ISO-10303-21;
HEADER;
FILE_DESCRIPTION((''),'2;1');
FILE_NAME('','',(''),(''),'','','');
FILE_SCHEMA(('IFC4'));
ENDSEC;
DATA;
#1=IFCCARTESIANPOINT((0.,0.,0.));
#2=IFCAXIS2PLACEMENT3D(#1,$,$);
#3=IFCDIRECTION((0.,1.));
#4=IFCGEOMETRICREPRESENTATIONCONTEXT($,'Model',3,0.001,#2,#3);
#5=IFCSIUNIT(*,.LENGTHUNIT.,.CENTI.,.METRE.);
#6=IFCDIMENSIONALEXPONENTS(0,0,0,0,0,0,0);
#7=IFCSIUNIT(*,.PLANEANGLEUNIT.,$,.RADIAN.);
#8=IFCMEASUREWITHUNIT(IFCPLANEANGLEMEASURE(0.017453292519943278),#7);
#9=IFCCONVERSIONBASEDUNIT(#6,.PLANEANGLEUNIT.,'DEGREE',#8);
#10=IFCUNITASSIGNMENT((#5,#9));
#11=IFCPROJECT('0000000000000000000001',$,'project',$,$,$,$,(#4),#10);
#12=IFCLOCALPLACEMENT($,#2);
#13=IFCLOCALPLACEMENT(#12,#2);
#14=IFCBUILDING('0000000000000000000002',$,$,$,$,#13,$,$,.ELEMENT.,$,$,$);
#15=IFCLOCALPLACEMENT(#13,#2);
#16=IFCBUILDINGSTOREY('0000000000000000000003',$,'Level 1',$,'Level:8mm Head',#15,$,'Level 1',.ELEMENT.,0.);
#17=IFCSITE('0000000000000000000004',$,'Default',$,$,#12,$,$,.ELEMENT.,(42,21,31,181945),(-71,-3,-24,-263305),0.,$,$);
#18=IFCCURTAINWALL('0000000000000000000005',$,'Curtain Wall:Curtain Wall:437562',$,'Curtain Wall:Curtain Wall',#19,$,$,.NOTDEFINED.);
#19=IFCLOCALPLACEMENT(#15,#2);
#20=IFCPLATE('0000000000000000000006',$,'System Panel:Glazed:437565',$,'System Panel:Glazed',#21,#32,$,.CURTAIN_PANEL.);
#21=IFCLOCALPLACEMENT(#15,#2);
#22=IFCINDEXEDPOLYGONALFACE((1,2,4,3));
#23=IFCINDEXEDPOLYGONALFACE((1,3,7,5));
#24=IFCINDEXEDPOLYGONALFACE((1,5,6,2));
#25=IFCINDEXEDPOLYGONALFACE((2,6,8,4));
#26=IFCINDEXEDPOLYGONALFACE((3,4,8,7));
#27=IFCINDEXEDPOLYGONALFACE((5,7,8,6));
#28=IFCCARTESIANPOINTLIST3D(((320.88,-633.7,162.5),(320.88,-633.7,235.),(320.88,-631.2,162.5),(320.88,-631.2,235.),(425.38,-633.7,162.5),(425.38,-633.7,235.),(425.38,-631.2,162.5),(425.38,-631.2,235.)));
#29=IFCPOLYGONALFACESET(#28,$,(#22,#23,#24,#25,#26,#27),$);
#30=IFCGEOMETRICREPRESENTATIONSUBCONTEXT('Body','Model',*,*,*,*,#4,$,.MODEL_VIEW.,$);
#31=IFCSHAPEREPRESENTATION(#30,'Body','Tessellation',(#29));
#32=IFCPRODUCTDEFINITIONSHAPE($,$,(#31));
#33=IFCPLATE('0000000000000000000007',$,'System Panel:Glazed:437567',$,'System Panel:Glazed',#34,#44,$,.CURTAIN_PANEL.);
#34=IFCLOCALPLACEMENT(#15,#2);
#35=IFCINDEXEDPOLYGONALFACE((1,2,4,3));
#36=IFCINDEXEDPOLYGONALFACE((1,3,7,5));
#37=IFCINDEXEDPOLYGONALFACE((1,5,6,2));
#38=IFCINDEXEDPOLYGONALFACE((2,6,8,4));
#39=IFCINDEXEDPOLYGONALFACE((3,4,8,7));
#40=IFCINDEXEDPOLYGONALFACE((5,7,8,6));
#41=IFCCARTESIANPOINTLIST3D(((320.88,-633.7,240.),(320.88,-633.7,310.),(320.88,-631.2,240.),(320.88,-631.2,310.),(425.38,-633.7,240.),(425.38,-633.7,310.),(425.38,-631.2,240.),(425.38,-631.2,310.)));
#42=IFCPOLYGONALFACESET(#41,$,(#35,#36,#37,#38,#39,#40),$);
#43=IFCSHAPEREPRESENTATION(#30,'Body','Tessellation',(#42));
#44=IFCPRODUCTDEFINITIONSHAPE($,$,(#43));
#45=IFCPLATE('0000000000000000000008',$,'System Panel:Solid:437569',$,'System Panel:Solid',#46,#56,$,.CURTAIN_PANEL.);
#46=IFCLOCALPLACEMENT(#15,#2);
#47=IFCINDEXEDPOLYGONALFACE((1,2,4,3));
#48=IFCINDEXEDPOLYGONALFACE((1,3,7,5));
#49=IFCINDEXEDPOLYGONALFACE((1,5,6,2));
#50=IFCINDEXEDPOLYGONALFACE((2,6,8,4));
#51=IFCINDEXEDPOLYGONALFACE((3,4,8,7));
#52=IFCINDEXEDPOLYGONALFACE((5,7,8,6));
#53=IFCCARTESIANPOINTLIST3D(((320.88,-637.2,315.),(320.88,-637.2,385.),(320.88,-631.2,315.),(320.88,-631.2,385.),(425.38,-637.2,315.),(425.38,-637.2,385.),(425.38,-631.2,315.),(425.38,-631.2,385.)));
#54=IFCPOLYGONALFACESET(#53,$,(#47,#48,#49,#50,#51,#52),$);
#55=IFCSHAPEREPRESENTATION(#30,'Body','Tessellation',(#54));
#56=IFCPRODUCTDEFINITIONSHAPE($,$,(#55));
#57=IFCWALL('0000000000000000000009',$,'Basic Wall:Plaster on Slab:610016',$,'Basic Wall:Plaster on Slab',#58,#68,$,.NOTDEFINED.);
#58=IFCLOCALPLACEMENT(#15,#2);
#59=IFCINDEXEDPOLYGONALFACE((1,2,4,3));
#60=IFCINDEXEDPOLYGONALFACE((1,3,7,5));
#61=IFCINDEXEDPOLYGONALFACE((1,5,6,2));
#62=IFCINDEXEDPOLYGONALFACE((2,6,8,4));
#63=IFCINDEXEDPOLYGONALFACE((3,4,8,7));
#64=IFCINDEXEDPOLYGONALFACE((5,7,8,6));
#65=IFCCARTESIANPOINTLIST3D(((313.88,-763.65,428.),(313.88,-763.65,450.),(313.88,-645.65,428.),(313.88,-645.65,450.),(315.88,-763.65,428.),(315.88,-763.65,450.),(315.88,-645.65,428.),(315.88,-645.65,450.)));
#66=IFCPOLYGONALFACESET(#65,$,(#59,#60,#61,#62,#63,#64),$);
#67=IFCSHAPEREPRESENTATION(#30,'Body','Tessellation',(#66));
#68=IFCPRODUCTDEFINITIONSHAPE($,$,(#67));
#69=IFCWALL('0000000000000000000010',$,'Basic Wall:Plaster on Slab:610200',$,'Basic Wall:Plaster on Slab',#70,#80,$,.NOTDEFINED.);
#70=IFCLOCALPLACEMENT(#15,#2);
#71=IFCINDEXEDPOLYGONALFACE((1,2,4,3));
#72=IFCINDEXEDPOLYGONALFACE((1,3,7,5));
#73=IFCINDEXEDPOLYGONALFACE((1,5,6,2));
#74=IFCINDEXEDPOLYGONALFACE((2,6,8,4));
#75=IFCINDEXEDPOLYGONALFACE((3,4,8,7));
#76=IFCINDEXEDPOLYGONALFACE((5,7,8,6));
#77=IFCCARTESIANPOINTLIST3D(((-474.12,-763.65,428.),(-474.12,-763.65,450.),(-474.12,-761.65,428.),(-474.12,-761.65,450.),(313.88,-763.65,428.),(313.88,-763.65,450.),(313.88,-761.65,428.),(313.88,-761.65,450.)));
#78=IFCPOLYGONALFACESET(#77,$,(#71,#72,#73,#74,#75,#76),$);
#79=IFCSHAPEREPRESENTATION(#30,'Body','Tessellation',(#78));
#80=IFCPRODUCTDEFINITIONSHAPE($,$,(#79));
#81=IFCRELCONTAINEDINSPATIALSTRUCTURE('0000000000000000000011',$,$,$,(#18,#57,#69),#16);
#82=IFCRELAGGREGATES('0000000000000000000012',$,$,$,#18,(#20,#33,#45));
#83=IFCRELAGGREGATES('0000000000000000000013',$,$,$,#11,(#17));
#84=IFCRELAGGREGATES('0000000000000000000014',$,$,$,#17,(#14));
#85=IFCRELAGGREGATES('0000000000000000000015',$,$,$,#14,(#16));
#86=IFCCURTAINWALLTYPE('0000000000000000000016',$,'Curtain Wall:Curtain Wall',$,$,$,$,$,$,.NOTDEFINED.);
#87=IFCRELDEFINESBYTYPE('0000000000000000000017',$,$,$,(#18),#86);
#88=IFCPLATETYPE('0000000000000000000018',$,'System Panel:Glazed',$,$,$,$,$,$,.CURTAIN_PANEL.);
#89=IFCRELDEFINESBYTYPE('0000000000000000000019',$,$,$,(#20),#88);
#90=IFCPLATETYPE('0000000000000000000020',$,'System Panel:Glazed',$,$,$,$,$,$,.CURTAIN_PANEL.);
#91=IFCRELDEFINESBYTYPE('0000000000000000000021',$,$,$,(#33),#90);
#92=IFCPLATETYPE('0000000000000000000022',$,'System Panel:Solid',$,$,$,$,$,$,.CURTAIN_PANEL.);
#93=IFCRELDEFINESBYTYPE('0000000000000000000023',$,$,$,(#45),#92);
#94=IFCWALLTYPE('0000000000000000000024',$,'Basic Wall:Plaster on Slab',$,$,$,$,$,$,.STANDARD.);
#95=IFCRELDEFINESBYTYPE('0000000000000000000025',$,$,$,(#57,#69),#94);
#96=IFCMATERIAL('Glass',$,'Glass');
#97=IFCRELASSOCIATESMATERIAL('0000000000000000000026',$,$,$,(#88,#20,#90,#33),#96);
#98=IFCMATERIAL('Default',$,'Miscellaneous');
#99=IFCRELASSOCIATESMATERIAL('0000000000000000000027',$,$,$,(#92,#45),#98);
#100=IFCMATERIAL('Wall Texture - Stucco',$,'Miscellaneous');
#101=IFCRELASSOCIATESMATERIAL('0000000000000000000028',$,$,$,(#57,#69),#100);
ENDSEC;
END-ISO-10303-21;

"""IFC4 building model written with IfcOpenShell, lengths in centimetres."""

from ifc_helpers import new_model, entity, si_unit, converted_unit, direction, frame, origin, place, context, subcontext, project, spatial, indexed_curve, outline, extrude, source, transform, mapped, material, type_object, type_shapes, element, aggregate, save


model = new_model("IFC4")

# Units and contexts
model_context = context("Model", 3, precision=0.001, world=origin(), true_north=direction((0.0, 1.0)))
body_context = subcontext(model_context, "Body", "Model", "MODEL_VIEW")
ifc_project = project(units=[si_unit("LENGTHUNIT", "METRE", prefix="CENTI"), converted_unit("PLANEANGLEUNIT", "DEGREE", entity("IfcPlaneAngleMeasure", 0.017453292519943278), si_unit("PLANEANGLEUNIT", "RADIAN"), dimensions=[0, 0, 0, 0, 0, 0, 0])], contexts=[model_context])

# Site, building, storey
site_placement = place(None, origin())
site = spatial("IfcSite", under=ifc_project, at=site_placement, Name="Default", CompositionType="ELEMENT", RefLatitude=(42, 21, 31, 181945), RefLongitude=(-71, -3, -24, -263305), RefElevation=0.0)
building_placement = place(site_placement, origin())
building = spatial("IfcBuilding", under=site, at=building_placement, CompositionType="ELEMENT")
storey_placement = place(building_placement, origin())
storey = spatial("IfcBuildingStorey", under=building, at=storey_placement, Name="Level 1", ObjectType="Level:8mm Head", LongName="Level 1", CompositionType="ELEMENT", Elevation=0.0)

# Curtain wall
curtain_wall_type = type_object("IfcCurtainWallType", Name="Curtain Wall:Curtain Wall", PredefinedType="NOTDEFINED")
curtain_wall_1_placement = place(storey_placement, origin())
curtain_wall_1 = element("IfcCurtainWall", 1, at=curtain_wall_1_placement, inside=storey, type_object=curtain_wall_type, Name="Curtain Wall:Curtain Wall:437562", ObjectType="Curtain Wall:Curtain Wall", PredefinedType="NOTDEFINED")

# Plates
ifc_material_1 = material(Name="Glass", Category="Glass")
plate_type_1 = type_object("IfcPlateType", Name="System Panel:Glazed", PredefinedType="CURTAIN_PANEL", material=ifc_material_1)
shared_shape_1 = source(origin(), body_context, "Body", "SweptSolid", [
    extrude(outline(indexed_curve([(-1.25, -52.25), (1.25, -52.25), (1.25, 52.25), (-1.25, 52.25), (-1.25, -52.25)], self_intersect=False)), frame((0.0, 3.7, 0.0), z_axis=(0.0, 0.0, 1.0), x_axis=(0.0, 1.0, 0.0)), (0.0, 0.0, 1.0), 72.5),
])
type_shapes(plate_type_1, [shared_shape_1])
plate_1_placement = place(curtain_wall_1_placement, frame((373.13, -636.15, 162.5)))
plate_1 = element("IfcPlate", 2, at=plate_1_placement, type_object=plate_type_1, material=ifc_material_1, Name="System Panel:Glazed:437565", ObjectType="System Panel:Glazed", PredefinedType="CURTAIN_PANEL", context=body_context, shape_type="MappedRepresentation", body=[
    mapped(shared_shape_1, transform((0.0, 0.0, 0.0), scale=1.0)),
])
plate_type_2 = type_object("IfcPlateType", Name="System Panel:Glazed", PredefinedType="CURTAIN_PANEL", material=ifc_material_1)
shared_shape_2 = source(origin(), body_context, "Body", "SweptSolid", [
    extrude(outline(indexed_curve([(-1.25, -52.25), (1.25, -52.25), (1.25, 52.25), (-1.25, 52.25), (-1.25, -52.25)], self_intersect=False)), frame((0.0, 3.7, 0.0), z_axis=(0.0, 0.0, 1.0), x_axis=(0.0, 1.0, 0.0)), (0.0, 0.0, 1.0), 70.0),
])
type_shapes(plate_type_2, [shared_shape_2])
plate_2_placement = place(curtain_wall_1_placement, frame((373.13, -636.15, 240.0)))
plate_2 = element("IfcPlate", 3, at=plate_2_placement, type_object=plate_type_2, material=ifc_material_1, Name="System Panel:Glazed:437567", ObjectType="System Panel:Glazed", PredefinedType="CURTAIN_PANEL", context=body_context, shape_type="MappedRepresentation", body=[
    mapped(shared_shape_2, transform((0.0, 0.0, 0.0), scale=1.0)),
])
ifc_material_2 = material(Name="Default", Category="Miscellaneous")
plate_type_3 = type_object("IfcPlateType", Name="System Panel:Solid", PredefinedType="CURTAIN_PANEL", material=ifc_material_2)
shared_shape_3 = source(origin(), body_context, "Body", "SweptSolid", [
    extrude(outline(indexed_curve([(-3.0, -52.25), (3.0, -52.25), (3.0, 52.25), (-3.0, 52.25), (-3.0, -52.25)], self_intersect=False)), frame((0.0, 1.95, 0.0), z_axis=(0.0, 0.0, 1.0), x_axis=(0.0, 1.0, 0.0)), (0.0, 0.0, 1.0), 70.0),
])
type_shapes(plate_type_3, [shared_shape_3])
plate_3_placement = place(curtain_wall_1_placement, frame((373.13, -636.15, 315.0)))
plate_3 = element("IfcPlate", 4, at=plate_3_placement, type_object=plate_type_3, material=ifc_material_2, Name="System Panel:Solid:437569", ObjectType="System Panel:Solid", PredefinedType="CURTAIN_PANEL", context=body_context, shape_type="MappedRepresentation", body=[
    mapped(shared_shape_3, transform((0.0, 0.0, 0.0), scale=1.0)),
])
aggregate(curtain_wall_1, [plate_1, plate_2, plate_3])

# Walls
ifc_material_3 = material(Name="Wall Texture - Stucco", Category="Miscellaneous")
wall_type = type_object("IfcWallType", Name="Basic Wall:Plaster on Slab", PredefinedType="STANDARD")
wall_1_placement = place(storey_placement, frame((314.88, -645.65, 428.0), z_axis=(0.0, 0.0, 1.0), x_axis=(0.0, -1.0, 0.0)))
element("IfcWall", 5, at=wall_1_placement, inside=storey, type_object=wall_type, material=ifc_material_3, Name="Basic Wall:Plaster on Slab:610016", ObjectType="Basic Wall:Plaster on Slab", PredefinedType="NOTDEFINED", context=body_context, shape_type="SweptSolid", body=[
    extrude(outline(indexed_curve([(118.0, 1.0), (0.0, 1.0), (0.0, -1.0), (118.0, -1.0), (118.0, 1.0)], self_intersect=False)), origin(), (0.0, 0.0, 1.0), 22.0),
])
wall_2_placement = place(storey_placement, frame((313.88, -762.65, 428.0), z_axis=(0.0, 0.0, 1.0), x_axis=(-1.0, 0.0, 0.0)))
element("IfcWall", 6, at=wall_2_placement, inside=storey, type_object=wall_type, material=ifc_material_3, Name="Basic Wall:Plaster on Slab:610200", ObjectType="Basic Wall:Plaster on Slab", PredefinedType="NOTDEFINED", context=body_context, shape_type="SweptSolid", body=[
    extrude(outline(indexed_curve([(788.0, 1.0), (0.0, 1.0), (0.0, -1.0), (788.0, -1.0), (788.0, 1.0)], self_intersect=False)), origin(), (0.0, 0.0, 1.0), 22.0),
])

save(model, "model.ifc")
